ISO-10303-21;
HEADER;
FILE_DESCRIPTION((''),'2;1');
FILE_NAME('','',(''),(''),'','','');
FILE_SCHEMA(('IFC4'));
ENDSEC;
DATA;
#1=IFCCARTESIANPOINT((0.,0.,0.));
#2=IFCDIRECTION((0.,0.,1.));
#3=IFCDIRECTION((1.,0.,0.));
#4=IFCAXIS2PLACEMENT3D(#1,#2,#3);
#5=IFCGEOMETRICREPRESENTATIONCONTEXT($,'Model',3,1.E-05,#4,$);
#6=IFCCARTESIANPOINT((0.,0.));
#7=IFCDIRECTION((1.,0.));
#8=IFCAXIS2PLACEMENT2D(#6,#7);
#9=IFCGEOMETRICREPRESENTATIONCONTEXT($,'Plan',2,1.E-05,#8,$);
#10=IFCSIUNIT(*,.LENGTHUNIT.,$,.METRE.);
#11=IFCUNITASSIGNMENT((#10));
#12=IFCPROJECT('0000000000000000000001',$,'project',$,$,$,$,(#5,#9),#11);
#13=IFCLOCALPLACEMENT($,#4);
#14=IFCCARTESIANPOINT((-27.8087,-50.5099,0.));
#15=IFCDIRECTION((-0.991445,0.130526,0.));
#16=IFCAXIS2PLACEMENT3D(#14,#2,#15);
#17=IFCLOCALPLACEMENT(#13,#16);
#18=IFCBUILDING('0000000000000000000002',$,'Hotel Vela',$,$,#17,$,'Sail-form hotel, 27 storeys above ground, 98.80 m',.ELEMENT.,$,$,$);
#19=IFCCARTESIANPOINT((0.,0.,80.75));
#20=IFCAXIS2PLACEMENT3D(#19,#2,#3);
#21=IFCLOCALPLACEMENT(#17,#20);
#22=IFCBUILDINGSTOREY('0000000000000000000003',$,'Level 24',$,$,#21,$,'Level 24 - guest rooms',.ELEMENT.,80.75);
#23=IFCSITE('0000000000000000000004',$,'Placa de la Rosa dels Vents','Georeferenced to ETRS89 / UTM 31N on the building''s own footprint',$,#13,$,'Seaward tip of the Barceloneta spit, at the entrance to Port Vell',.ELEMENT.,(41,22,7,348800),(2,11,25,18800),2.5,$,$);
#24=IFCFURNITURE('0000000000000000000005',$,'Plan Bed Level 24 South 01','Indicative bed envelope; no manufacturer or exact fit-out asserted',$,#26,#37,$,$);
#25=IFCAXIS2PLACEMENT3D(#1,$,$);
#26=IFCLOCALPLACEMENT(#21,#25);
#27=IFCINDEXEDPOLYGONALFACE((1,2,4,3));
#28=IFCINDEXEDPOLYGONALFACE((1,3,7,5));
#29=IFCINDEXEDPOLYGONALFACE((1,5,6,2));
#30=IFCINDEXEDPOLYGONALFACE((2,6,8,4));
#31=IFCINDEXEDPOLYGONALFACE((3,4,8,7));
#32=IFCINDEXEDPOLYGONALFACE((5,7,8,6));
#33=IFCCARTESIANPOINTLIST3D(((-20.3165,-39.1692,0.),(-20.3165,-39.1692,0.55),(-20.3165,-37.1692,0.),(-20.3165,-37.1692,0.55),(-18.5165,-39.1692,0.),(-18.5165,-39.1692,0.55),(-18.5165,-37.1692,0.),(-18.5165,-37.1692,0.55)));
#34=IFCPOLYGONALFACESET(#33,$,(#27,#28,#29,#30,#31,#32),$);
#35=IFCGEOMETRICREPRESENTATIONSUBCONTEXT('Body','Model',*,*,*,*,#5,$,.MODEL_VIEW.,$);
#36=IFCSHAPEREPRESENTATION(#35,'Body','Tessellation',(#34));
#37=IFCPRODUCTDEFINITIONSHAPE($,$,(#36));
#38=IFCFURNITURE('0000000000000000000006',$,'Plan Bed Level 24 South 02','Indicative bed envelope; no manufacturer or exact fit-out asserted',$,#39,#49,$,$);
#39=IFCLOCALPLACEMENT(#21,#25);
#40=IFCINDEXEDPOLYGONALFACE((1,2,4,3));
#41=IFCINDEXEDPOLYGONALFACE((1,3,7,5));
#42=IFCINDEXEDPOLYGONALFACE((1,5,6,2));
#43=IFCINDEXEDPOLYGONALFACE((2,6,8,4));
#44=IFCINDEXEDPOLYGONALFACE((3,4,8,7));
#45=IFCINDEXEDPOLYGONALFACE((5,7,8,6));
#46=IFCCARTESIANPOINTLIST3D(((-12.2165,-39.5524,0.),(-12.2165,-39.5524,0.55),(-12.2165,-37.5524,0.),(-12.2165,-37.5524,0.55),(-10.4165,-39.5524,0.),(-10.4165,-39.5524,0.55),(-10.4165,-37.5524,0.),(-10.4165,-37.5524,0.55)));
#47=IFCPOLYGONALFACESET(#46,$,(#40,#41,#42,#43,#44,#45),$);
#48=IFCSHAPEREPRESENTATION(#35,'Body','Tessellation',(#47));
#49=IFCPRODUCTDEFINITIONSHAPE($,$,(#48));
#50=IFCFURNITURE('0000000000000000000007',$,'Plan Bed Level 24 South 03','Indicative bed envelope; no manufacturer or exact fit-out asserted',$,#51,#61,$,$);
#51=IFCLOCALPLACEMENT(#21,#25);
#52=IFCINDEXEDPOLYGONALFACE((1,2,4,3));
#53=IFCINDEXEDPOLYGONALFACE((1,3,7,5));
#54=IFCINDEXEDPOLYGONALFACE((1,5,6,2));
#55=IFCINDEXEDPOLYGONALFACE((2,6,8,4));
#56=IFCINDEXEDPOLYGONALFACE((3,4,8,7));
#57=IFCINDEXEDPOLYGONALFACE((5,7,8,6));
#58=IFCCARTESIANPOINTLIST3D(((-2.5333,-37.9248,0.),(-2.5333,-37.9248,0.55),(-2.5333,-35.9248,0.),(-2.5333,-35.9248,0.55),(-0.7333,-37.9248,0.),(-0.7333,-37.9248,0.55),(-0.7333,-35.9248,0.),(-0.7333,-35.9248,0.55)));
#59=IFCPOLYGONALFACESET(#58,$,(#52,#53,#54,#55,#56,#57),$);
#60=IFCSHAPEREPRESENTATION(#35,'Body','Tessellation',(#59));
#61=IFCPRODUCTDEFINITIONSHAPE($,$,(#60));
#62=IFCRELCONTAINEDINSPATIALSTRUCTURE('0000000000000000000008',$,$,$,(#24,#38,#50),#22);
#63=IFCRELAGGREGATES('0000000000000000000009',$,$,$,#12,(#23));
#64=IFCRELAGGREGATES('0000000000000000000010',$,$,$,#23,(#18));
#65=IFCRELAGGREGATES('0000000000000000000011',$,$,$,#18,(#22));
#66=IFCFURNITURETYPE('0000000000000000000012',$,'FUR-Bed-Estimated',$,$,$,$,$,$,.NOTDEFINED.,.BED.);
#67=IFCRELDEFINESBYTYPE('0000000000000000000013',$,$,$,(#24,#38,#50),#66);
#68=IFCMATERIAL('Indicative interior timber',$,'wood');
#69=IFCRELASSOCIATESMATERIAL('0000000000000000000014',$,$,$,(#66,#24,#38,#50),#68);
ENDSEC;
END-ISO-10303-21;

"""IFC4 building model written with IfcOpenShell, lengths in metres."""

from ifc_helpers import new_model, si_unit, frame, origin_with_axes, origin_2d_with_axis, place, context, subcontext, project, spatial, line, indexed_curve, outline, extrude, material, type_object, element, save


model = new_model("IFC4")

# Units and contexts
model_context = context("Model", 3, precision=1e-05, world=origin_with_axes())
plan_context = context("Plan", 2, precision=1e-05, world=origin_2d_with_axis())
body_context = subcontext(model_context, "Body", "Model", "MODEL_VIEW")
ifc_project = project(units=[si_unit("LENGTHUNIT", "METRE")], contexts=[model_context, plan_context])

# Site, building, storey
site_placement = place(None, origin_with_axes())
site = spatial("IfcSite", under=ifc_project, at=site_placement, Name="Placa de la Rosa dels Vents", Description="Georeferenced to ETRS89 / UTM 31N on the building's own footprint", LongName="Seaward tip of the Barceloneta spit, at the entrance to Port Vell", CompositionType="ELEMENT", RefLatitude=(41, 22, 7, 348800), RefLongitude=(2, 11, 25, 18800), RefElevation=2.5)
building_placement = place(site_placement, frame((-27.8087, -50.5099, 0.0), z_axis=(0.0, 0.0, 1.0), x_axis=(-0.991445, 0.130526, 0.0)))
building = spatial("IfcBuilding", under=site, at=building_placement, Name="Hotel Vela", LongName="Sail-form hotel, 27 storeys above ground, 98.80 m", CompositionType="ELEMENT")
storey_placement = place(building_placement, frame((0.0, 0.0, 80.75), z_axis=(0.0, 0.0, 1.0), x_axis=(1.0, 0.0, 0.0)))
storey = spatial("IfcBuildingStorey", under=building, at=storey_placement, Name="Level 24", LongName="Level 24 - guest rooms", CompositionType="ELEMENT", Elevation=80.75)

# Shared definitions
ifc_material_1 = material(Name="Indicative interior timber", Category="wood")

# Furniture
furniture_type = type_object("IfcFurnitureType", Name="FUR-Bed-Estimated", AssemblyPlace="NOTDEFINED", PredefinedType="BED", material=ifc_material_1)
for number, where, z_axis, x_axis, name in (
    (1, (-20.3165, -39.1692, 0.0), (0.0, 0.0, 1.0), (1.0, 0.0, 0.0), "Plan Bed Level 24 South 01"),
    (2, (-12.2165, -39.5524, 0.0), (0.0, 0.0, 1.0), (1.0, 0.0, 0.0), "Plan Bed Level 24 South 02"),
    (3, (-2.5333, -37.9248, 0.0), (0.0, 0.0, 1.0), (1.0, 0.0, 0.0), "Plan Bed Level 24 South 03"),
):
    element("IfcFurniture", number, at=place(storey_placement, frame(where, z_axis=z_axis, x_axis=x_axis)), inside=storey, type_object=furniture_type, material=ifc_material_1, Name=name, Description="Indicative bed envelope; no manufacturer or exact fit-out asserted", context=body_context, shape_type="SweptSolid", body=[
        extrude(outline(indexed_curve([(0.0, 0.0), (1.8, 0.0), (1.8, 2.0), (0.0, 2.0)], segments=[line(1, 2, 3, 4, 1)])), origin_with_axes(), (0.0, 0.0, 1.0), 0.55),
    ])

save(model, "model.ifc")
